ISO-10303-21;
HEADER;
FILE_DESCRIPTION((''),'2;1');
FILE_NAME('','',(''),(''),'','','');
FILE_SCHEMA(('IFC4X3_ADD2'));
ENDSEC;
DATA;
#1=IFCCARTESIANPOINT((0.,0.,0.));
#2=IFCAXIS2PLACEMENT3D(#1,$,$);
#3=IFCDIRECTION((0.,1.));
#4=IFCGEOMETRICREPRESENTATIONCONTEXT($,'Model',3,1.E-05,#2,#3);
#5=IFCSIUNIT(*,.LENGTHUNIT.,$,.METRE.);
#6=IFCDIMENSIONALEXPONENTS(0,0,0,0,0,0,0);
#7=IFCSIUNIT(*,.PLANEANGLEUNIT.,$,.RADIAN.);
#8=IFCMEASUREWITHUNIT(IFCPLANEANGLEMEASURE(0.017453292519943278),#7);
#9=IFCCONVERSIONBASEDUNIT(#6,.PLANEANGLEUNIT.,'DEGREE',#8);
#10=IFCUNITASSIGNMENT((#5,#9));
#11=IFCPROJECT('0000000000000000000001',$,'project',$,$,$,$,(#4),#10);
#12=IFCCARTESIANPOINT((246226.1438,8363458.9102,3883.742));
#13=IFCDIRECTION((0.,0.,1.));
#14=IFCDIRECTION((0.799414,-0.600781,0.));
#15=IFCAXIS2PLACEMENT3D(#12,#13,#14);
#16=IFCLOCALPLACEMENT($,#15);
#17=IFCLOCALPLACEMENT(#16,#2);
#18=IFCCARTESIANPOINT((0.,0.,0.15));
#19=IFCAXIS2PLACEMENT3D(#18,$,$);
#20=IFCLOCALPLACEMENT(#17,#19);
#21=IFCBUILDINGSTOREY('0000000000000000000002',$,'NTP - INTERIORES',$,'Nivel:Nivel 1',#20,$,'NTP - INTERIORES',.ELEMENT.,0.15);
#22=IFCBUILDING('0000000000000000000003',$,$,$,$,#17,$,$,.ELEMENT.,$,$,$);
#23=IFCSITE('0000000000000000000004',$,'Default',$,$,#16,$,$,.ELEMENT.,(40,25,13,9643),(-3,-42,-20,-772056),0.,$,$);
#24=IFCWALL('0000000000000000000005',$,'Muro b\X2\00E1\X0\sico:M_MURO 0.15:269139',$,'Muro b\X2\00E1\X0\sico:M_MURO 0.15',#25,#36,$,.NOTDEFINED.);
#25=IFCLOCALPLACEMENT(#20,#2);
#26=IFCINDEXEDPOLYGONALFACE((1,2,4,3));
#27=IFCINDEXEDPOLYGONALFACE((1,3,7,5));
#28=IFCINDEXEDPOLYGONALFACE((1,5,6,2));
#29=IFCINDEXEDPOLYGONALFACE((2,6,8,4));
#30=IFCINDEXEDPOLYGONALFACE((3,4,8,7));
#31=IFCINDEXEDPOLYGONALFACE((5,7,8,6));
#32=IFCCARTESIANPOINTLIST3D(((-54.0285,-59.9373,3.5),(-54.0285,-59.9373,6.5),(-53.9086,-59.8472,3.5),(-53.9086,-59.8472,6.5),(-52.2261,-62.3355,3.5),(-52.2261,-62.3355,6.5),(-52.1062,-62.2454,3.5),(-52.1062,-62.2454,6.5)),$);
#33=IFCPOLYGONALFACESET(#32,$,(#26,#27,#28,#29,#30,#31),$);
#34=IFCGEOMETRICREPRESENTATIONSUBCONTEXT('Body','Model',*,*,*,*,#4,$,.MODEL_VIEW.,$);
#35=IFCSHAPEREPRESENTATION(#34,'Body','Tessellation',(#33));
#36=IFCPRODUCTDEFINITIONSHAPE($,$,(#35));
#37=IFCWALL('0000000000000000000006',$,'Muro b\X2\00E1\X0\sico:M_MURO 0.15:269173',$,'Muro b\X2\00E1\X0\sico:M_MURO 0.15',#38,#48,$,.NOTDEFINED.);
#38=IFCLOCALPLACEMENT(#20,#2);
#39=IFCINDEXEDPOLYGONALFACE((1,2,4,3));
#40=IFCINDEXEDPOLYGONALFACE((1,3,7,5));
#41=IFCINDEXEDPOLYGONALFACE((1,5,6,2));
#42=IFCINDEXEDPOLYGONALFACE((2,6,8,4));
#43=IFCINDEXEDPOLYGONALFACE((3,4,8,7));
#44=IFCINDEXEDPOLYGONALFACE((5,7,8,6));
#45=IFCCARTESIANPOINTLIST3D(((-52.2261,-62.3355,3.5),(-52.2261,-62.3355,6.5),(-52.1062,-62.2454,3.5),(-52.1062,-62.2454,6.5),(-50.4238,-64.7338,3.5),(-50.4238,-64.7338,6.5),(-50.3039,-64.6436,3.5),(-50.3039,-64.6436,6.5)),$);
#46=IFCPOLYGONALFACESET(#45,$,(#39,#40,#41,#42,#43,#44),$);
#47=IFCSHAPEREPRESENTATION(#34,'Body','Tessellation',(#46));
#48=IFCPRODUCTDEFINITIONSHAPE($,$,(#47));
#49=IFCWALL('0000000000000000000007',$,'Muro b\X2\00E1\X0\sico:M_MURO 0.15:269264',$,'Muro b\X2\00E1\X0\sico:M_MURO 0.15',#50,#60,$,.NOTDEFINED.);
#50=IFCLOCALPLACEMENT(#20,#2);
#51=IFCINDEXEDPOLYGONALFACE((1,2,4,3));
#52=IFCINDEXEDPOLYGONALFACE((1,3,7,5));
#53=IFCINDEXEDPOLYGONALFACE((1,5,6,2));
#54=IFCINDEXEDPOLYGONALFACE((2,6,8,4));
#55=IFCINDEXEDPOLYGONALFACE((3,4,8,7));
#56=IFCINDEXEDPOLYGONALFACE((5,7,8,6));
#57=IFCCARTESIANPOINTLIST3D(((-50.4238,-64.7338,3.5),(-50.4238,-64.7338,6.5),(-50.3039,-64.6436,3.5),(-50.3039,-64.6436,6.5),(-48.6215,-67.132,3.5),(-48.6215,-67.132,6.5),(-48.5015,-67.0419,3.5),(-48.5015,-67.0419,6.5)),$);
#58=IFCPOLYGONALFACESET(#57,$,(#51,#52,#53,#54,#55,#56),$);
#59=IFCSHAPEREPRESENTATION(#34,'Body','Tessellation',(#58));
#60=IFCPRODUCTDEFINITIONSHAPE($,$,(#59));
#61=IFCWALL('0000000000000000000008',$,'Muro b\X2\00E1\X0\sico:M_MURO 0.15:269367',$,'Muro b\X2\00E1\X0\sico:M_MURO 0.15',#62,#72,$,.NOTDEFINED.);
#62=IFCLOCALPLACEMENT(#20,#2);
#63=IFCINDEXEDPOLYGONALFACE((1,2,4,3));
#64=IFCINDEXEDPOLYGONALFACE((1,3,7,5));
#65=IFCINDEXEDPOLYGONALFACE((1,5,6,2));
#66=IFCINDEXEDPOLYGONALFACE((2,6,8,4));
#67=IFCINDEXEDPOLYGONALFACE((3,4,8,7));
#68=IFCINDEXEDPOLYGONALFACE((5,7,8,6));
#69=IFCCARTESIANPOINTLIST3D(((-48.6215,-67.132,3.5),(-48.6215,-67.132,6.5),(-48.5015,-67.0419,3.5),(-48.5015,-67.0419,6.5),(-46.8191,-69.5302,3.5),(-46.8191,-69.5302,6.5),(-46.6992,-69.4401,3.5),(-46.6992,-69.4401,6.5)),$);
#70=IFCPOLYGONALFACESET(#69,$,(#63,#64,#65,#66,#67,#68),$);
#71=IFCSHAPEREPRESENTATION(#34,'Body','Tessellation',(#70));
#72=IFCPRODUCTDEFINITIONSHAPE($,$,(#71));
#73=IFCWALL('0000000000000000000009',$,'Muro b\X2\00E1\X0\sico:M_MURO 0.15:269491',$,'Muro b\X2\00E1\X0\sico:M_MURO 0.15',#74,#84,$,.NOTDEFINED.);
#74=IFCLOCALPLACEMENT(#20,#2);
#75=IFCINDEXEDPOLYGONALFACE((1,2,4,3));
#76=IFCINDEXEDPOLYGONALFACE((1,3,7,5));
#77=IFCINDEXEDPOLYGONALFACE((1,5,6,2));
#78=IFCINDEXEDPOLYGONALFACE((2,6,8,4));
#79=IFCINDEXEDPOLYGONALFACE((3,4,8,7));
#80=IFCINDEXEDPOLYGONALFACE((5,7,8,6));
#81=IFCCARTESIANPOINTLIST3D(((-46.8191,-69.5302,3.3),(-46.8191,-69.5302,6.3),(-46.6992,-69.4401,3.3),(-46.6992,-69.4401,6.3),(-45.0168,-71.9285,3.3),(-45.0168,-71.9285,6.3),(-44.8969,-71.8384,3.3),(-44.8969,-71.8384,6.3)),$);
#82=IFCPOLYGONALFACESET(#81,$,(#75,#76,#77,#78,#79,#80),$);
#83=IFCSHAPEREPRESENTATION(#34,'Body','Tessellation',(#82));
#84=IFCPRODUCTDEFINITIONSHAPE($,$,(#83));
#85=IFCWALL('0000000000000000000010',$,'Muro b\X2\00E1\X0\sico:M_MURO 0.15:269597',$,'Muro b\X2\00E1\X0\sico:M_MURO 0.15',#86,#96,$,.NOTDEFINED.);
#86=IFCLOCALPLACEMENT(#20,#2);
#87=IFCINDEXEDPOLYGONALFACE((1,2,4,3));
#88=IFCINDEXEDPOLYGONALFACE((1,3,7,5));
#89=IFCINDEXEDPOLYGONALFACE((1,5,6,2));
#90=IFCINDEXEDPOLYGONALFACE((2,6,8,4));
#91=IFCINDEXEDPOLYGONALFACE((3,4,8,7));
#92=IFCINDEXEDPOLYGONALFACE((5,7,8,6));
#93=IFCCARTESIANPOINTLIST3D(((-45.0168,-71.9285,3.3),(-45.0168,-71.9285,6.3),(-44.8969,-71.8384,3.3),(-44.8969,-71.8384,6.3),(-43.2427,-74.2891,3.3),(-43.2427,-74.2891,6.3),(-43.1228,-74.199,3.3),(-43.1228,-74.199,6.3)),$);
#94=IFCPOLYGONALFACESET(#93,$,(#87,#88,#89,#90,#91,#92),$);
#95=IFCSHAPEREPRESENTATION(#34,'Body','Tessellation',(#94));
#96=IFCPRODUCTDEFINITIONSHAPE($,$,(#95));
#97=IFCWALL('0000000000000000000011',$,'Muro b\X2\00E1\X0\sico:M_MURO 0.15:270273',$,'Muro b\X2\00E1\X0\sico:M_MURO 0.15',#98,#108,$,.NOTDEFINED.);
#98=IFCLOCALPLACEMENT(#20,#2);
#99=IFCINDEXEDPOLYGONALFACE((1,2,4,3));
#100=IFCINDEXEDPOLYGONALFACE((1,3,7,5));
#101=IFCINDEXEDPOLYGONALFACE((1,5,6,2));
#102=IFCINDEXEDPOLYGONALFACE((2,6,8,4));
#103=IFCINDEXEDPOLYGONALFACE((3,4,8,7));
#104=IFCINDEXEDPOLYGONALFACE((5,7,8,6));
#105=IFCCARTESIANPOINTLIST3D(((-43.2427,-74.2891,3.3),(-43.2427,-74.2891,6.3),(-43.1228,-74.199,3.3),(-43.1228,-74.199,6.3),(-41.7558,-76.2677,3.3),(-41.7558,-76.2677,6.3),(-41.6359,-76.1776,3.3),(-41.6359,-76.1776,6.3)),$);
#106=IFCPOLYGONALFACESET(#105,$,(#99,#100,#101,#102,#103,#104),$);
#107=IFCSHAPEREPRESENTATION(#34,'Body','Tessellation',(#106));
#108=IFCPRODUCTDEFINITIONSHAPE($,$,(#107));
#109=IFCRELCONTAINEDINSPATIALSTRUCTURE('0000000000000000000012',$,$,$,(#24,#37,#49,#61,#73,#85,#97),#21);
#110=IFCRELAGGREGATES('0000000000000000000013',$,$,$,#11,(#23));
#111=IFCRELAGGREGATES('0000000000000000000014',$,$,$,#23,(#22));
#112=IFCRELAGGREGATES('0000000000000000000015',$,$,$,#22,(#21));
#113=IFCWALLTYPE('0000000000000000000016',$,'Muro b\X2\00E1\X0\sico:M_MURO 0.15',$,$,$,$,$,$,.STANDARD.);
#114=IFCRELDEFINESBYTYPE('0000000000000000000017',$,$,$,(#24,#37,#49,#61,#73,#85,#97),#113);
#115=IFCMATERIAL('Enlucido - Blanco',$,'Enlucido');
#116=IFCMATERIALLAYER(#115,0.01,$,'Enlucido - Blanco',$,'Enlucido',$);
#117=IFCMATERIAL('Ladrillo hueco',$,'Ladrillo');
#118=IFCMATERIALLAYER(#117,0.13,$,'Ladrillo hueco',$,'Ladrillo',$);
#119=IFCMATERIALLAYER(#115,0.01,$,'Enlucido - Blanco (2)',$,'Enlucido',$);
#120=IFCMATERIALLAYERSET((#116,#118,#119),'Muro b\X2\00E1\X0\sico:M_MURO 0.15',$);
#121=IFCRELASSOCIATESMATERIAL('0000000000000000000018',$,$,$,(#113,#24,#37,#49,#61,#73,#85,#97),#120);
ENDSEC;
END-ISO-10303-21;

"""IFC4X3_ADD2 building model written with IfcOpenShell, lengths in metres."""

from ifc_helpers import new_model, entity, si_unit, converted_unit, direction, frame, frame_2d, origin, place, context, subcontext, project, spatial, rectangle, extrude, material, layer, layer_set, type_object, element, save


model = new_model("IFC4X3_ADD2")

# Units and contexts
model_context = context("Model", 3, precision=1e-05, world=origin(), true_north=direction((0.0, 1.0)))
body_context = subcontext(model_context, "Body", "Model", "MODEL_VIEW")
ifc_project = project(units=[si_unit("LENGTHUNIT", "METRE"), converted_unit("PLANEANGLEUNIT", "DEGREE", entity("IfcPlaneAngleMeasure", 0.017453292519943278), si_unit("PLANEANGLEUNIT", "RADIAN"), dimensions=[0, 0, 0, 0, 0, 0, 0])], contexts=[model_context])

# Site, building, storey
site_placement = place(None, frame((246226.1438, 8363458.9102, 3883.742), z_axis=(0.0, 0.0, 1.0), x_axis=(0.799414, -0.600781, 0.0)))
site = spatial("IfcSite", under=ifc_project, at=site_placement, Name="Default", CompositionType="ELEMENT", RefLatitude=(40, 25, 13, 9643), RefLongitude=(-3, -42, -20, -772056), RefElevation=0.0)
building_placement = place(site_placement, origin())
building = spatial("IfcBuilding", under=site, at=building_placement, CompositionType="ELEMENT")
storey_placement = place(building_placement, frame((0.0, 0.0, 0.15)))
storey = spatial("IfcBuildingStorey", under=building, at=storey_placement, Name="NTP - INTERIORES", ObjectType="Nivel:Nivel 1", LongName="NTP - INTERIORES", CompositionType="ELEMENT", Elevation=0.15)

# Walls
ifc_material_1 = material(Name="Enlucido - Blanco", Category="Enlucido")
ifc_layer_1 = layer(ifc_material_1, 0.01, Name="Enlucido - Blanco", Category="Enlucido")
ifc_material_2 = material(Name="Ladrillo hueco", Category="Ladrillo")
ifc_layer_2 = layer(ifc_material_2, 0.13, Name="Ladrillo hueco", Category="Ladrillo")
ifc_layer_3 = layer(ifc_material_1, 0.01, Name="Enlucido - Blanco (2)", Category="Enlucido")
ifc_layer_set_1 = layer_set([ifc_layer_1, ifc_layer_2, ifc_layer_3], Name="Muro básico:M_MURO 0.15")
wall_type = type_object("IfcWallType", Name="Muro básico:M_MURO 0.15", PredefinedType="STANDARD", material=ifc_layer_set_1)
wall_1_placement = place(storey_placement, frame((-53.9685, -59.8922, 3.5), z_axis=(0.0, 0.0, 1.0), x_axis=(0.60078, -0.799414, 0.0)))
element("IfcWall", 1, at=wall_1_placement, inside=storey, type_object=wall_type, material=ifc_layer_set_1, Name="Muro básico:M_MURO 0.15:269139", ObjectType="Muro básico:M_MURO 0.15", PredefinedType="NOTDEFINED", context=body_context, shape_type="SweptSolid", body=[
    extrude(rectangle(XDim=3.0, YDim=0.15, at=frame_2d((1.5, 0.0), x_axis=(-1.0, 0.0))), origin(), (0.0, 0.0, 1.0), 3.0),
])
wall_2_placement = place(storey_placement, frame((-52.1662, -62.2905, 3.5), z_axis=(0.0, 0.0, 1.0), x_axis=(0.60078, -0.799414, 0.0)))
element("IfcWall", 2, at=wall_2_placement, inside=storey, type_object=wall_type, material=ifc_layer_set_1, Name="Muro básico:M_MURO 0.15:269173", ObjectType="Muro básico:M_MURO 0.15", PredefinedType="NOTDEFINED", context=body_context, shape_type="SweptSolid", body=[
    extrude(rectangle(XDim=3.0, YDim=0.15, at=frame_2d((1.5, 0.0), x_axis=(-1.0, 0.0))), origin(), (0.0, 0.0, 1.0), 3.0),
])
wall_3_placement = place(storey_placement, frame((-50.3638, -64.6887, 3.5), z_axis=(0.0, 0.0, 1.0), x_axis=(0.60078, -0.799414, 0.0)))
element("IfcWall", 3, at=wall_3_placement, inside=storey, type_object=wall_type, material=ifc_layer_set_1, Name="Muro básico:M_MURO 0.15:269264", ObjectType="Muro básico:M_MURO 0.15", PredefinedType="NOTDEFINED", context=body_context, shape_type="SweptSolid", body=[
    extrude(rectangle(XDim=3.0, YDim=0.15, at=frame_2d((1.5, 0.0), x_axis=(-1.0, 0.0))), origin(), (0.0, 0.0, 1.0), 3.0),
])
for number, where, z_axis, x_axis, name in (
    (4, (-48.5615, -67.0869, 3.5), (0.0, 0.0, 1.0), (0.60078, -0.799414, 0.0), "Muro básico:M_MURO 0.15:269367"),
    (5, (-46.7592, -69.4852, 3.3), (0.0, 0.0, 1.0), (0.60078, -0.799414, 0.0), "Muro básico:M_MURO 0.15:269491"),
):
    element("IfcWall", number, at=place(storey_placement, frame(where, z_axis=z_axis, x_axis=x_axis)), inside=storey, type_object=wall_type, material=ifc_layer_set_1, Name=name, ObjectType="Muro básico:M_MURO 0.15", PredefinedType="NOTDEFINED", context=body_context, shape_type="SweptSolid", body=[
        extrude(rectangle(XDim=3.0, YDim=0.15, at=frame_2d((1.5, 0.0), x_axis=(-1.0, 0.0))), origin(), (0.0, 0.0, 1.0), 3.0),
    ])
wall_4_placement = place(storey_placement, frame((-44.9568, -71.8834, 3.3), z_axis=(0.0, 0.0, 1.0), x_axis=(0.60078, -0.799414, 0.0)))
element("IfcWall", 6, at=wall_4_placement, inside=storey, type_object=wall_type, material=ifc_layer_set_1, Name="Muro básico:M_MURO 0.15:269597", ObjectType="Muro básico:M_MURO 0.15", PredefinedType="NOTDEFINED", context=body_context, shape_type="SweptSolid", body=[
    extrude(rectangle(XDim=2.9529, YDim=0.15, at=frame_2d((1.4765, 0.0), x_axis=(-1.0, 0.0))), origin(), (0.0, 0.0, 1.0), 3.0),
])
wall_5_placement = place(storey_placement, frame((-43.1827, -74.2441, 3.3), z_axis=(0.0, 0.0, 1.0), x_axis=(0.60078, -0.799414, 0.0)))
element("IfcWall", 7, at=wall_5_placement, inside=storey, type_object=wall_type, material=ifc_layer_set_1, Name="Muro básico:M_MURO 0.15:270273", ObjectType="Muro básico:M_MURO 0.15", PredefinedType="NOTDEFINED", context=body_context, shape_type="SweptSolid", body=[
    extrude(rectangle(XDim=2.475, YDim=0.15, at=frame_2d((1.2375, 0.0), x_axis=(-1.0, 0.0))), origin(), (0.0, 0.0, 1.0), 3.0),
])

save(model, "model.ifc")
